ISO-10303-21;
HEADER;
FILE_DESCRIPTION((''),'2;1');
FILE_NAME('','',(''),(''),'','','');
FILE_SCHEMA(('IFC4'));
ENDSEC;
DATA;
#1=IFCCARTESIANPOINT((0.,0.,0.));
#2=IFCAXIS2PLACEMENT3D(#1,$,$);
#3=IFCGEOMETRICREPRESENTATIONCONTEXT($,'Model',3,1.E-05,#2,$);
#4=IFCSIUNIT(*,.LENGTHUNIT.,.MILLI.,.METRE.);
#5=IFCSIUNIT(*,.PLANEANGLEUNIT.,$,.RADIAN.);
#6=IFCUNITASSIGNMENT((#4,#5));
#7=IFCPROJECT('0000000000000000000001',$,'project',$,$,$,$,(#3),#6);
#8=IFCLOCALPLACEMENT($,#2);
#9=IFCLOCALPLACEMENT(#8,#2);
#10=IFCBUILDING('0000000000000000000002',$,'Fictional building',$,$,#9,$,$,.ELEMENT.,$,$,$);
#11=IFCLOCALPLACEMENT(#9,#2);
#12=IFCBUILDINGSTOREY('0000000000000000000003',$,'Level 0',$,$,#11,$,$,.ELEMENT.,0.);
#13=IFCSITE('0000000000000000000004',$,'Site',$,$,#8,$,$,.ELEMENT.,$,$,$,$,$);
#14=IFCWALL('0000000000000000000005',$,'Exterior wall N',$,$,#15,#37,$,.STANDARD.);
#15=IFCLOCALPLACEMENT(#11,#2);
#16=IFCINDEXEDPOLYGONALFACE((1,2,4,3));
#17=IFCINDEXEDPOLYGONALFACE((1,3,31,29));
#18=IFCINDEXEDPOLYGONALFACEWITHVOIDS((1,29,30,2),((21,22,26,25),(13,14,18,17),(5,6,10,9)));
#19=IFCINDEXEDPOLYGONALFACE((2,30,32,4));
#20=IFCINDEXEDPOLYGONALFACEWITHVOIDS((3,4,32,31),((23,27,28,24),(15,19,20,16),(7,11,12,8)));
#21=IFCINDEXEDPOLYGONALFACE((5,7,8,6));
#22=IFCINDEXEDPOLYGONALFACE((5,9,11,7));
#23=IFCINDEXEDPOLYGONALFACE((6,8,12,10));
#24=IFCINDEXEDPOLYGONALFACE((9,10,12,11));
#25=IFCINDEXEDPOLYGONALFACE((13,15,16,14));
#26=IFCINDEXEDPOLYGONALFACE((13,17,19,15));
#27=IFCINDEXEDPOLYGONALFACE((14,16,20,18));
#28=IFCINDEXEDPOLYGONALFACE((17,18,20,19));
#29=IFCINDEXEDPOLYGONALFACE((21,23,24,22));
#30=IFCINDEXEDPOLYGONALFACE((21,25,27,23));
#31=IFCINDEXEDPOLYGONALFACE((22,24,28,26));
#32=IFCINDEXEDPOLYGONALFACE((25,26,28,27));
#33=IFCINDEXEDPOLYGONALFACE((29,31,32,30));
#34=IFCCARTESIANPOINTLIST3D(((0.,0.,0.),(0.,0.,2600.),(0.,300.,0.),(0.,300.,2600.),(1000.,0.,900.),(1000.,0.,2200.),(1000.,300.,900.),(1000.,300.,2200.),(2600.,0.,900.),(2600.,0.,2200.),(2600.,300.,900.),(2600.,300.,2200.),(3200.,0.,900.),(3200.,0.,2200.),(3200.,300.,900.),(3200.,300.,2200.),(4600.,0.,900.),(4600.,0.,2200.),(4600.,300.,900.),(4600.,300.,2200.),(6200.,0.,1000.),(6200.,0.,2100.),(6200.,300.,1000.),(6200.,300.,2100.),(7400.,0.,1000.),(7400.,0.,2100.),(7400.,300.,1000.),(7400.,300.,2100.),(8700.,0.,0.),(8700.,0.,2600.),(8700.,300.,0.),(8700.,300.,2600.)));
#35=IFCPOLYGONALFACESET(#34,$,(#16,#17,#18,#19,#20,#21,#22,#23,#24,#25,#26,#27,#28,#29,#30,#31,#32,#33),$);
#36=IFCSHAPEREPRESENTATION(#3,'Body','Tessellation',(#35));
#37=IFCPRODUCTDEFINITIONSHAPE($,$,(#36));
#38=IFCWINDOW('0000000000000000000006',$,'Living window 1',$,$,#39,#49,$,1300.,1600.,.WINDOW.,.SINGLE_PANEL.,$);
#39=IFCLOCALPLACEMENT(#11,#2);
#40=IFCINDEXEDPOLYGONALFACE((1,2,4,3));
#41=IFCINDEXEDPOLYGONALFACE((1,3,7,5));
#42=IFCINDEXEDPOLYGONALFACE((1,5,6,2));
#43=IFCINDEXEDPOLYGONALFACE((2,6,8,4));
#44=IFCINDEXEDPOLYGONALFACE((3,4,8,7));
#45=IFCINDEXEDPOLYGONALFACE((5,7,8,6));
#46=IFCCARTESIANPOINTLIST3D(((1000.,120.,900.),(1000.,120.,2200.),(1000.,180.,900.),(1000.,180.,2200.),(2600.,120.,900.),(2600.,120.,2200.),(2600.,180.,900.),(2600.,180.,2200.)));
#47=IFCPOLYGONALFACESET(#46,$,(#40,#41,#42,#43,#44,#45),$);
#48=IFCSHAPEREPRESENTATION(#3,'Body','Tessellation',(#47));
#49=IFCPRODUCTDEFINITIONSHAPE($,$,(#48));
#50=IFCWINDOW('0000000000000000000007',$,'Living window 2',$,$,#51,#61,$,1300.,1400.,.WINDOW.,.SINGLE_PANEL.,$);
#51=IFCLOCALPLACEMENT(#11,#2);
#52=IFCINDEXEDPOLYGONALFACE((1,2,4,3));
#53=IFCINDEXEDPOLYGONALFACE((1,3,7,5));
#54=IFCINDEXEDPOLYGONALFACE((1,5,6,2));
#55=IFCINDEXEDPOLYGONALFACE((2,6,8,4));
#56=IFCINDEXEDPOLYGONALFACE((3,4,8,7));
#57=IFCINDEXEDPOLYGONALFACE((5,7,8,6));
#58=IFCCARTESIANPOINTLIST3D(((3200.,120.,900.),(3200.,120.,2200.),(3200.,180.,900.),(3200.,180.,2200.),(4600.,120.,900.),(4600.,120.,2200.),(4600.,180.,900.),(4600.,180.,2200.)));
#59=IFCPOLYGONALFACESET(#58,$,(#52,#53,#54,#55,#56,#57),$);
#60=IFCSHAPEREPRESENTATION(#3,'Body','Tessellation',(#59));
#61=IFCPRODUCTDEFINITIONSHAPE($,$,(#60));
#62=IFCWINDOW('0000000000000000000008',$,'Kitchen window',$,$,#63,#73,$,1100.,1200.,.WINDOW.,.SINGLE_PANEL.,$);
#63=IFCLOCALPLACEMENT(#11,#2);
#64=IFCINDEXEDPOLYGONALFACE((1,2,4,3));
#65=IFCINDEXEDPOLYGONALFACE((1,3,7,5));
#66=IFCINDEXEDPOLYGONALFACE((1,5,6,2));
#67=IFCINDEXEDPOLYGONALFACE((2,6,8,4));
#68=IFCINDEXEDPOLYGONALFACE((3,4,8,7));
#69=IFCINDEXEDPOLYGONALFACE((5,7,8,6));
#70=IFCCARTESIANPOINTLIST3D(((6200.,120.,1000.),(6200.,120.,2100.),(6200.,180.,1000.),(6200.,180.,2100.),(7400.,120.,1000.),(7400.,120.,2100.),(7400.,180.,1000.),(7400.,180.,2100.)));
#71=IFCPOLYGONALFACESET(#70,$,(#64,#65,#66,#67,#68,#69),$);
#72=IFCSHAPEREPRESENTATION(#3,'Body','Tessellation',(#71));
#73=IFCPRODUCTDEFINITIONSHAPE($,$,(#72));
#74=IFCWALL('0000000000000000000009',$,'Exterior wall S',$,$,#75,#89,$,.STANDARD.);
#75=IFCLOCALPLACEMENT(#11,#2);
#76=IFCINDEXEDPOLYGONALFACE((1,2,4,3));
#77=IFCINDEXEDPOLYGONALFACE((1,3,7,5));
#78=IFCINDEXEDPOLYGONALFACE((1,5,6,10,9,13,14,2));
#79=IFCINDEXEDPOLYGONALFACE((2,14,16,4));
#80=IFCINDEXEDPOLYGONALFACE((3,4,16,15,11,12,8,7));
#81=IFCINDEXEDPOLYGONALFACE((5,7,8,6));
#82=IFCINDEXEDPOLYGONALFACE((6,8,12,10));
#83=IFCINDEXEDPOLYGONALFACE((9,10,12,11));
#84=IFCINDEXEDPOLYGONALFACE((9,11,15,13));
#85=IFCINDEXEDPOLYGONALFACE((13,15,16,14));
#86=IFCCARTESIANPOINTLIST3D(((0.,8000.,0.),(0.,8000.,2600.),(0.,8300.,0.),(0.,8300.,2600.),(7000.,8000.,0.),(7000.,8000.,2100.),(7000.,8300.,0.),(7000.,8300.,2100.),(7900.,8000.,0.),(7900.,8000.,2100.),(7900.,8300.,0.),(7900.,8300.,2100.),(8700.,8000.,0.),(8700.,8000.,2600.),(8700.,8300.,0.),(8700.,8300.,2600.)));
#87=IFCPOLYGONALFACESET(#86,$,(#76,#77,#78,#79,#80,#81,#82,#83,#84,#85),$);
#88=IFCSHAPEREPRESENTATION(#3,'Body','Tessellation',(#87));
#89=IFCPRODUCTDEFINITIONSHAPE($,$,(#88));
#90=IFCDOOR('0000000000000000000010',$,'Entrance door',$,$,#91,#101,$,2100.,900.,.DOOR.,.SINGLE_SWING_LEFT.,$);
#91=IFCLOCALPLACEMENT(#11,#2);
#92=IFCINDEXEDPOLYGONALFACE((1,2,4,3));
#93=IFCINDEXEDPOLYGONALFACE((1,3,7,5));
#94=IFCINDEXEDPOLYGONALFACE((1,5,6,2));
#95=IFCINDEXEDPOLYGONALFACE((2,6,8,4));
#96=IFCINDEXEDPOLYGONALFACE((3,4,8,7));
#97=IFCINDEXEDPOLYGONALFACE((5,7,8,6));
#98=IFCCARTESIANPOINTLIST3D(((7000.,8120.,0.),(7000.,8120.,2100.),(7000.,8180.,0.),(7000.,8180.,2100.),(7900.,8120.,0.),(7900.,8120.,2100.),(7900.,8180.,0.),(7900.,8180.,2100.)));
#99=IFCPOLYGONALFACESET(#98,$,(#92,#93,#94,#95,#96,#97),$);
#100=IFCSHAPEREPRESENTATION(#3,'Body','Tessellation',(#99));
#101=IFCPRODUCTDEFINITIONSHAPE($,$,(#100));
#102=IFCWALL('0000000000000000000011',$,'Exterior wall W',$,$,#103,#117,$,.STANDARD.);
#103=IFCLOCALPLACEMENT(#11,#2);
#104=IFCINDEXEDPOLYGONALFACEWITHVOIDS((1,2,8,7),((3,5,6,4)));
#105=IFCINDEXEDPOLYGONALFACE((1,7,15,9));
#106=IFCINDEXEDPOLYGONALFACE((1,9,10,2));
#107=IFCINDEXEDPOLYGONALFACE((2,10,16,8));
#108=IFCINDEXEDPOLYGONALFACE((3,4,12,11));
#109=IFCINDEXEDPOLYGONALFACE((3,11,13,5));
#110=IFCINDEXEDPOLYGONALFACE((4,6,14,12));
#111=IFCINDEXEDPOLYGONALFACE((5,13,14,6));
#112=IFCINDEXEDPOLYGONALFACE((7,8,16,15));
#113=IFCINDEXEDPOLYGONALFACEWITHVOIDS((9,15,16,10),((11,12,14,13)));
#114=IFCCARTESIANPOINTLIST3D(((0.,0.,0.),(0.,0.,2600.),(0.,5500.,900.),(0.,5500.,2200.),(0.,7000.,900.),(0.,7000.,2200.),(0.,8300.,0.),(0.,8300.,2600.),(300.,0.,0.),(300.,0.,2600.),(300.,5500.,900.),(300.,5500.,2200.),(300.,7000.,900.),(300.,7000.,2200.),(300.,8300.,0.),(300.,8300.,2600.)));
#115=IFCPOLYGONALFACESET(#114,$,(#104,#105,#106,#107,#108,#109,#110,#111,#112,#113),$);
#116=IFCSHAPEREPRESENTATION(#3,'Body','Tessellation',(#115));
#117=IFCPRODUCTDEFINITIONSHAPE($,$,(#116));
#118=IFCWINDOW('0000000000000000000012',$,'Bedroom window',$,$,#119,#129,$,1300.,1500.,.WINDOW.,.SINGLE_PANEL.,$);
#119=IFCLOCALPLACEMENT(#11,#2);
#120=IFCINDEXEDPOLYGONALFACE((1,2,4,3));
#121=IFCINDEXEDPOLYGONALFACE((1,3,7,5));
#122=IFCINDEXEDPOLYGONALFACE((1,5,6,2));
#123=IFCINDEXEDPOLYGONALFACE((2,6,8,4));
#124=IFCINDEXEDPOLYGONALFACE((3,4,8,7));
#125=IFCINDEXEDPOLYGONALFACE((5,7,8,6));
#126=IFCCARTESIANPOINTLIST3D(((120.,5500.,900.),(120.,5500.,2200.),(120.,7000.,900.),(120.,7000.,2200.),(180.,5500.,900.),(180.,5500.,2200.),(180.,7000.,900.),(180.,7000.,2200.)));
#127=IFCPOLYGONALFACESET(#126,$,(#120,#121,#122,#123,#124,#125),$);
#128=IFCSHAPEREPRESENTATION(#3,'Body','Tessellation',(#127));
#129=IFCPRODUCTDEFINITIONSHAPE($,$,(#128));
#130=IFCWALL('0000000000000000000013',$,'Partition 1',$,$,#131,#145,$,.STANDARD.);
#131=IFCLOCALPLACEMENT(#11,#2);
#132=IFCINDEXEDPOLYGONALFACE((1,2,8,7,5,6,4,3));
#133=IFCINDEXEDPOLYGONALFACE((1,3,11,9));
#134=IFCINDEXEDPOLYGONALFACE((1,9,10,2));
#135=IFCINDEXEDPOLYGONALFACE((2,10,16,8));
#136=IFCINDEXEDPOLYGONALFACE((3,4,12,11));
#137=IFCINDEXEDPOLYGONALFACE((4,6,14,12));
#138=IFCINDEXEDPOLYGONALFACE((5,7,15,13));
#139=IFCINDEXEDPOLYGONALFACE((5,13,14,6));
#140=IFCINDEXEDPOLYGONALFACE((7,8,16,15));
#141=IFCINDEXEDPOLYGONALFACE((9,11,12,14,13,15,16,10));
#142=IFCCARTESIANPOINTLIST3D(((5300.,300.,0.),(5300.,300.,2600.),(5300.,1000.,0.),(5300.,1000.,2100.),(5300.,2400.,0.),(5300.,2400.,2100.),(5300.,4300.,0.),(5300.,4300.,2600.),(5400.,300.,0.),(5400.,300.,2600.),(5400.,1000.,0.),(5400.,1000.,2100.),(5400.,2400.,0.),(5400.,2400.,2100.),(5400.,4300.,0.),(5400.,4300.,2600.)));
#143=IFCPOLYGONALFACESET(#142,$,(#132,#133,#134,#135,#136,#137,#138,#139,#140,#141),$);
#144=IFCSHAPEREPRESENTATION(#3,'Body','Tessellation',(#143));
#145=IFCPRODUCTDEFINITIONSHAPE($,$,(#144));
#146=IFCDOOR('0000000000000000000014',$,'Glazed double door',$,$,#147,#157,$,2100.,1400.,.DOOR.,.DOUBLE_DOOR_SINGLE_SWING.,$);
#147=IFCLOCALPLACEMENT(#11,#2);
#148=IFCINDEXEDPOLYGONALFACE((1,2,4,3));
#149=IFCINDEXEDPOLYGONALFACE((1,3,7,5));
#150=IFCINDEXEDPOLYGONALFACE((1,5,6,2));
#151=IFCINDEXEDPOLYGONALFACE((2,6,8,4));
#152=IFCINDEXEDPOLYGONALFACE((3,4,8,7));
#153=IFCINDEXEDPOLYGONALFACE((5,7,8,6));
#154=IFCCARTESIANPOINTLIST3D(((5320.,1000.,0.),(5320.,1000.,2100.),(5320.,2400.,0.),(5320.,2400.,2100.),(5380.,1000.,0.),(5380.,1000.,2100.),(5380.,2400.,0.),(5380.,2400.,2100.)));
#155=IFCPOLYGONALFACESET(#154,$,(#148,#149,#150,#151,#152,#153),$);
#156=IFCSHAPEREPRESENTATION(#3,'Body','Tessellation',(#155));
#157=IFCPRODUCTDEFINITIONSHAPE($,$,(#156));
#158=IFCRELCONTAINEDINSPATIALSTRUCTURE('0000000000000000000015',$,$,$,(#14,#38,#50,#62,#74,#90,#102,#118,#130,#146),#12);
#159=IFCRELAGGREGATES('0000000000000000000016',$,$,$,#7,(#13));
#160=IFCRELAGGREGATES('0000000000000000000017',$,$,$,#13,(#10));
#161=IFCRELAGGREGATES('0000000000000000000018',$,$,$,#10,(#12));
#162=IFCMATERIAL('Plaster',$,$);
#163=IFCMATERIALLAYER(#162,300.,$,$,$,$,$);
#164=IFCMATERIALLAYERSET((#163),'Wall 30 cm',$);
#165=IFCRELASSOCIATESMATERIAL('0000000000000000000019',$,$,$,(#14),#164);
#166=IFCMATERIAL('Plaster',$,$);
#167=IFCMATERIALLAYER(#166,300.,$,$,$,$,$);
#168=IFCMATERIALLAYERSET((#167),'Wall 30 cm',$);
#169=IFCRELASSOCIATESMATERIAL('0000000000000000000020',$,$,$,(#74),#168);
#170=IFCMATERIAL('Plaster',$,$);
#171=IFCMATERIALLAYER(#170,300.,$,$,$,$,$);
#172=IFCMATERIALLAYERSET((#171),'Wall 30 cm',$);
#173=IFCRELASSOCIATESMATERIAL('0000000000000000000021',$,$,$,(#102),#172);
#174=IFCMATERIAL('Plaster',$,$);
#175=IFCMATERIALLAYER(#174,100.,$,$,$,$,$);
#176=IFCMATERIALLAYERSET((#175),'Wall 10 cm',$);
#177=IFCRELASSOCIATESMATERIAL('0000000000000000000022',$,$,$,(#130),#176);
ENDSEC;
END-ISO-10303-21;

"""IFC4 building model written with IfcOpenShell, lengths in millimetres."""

from ifc_helpers import new_model, si_unit, frame, frame_2d, origin, place, context, project, spatial, rectangle, extrude, material, layer, layer_set, layer_usage, element, fill, save


model = new_model("IFC4")

# Units and contexts
model_context = context("Model", 3, precision=1e-05, world=origin())
ifc_project = project(units=[si_unit("LENGTHUNIT", "METRE", prefix="MILLI"), si_unit("PLANEANGLEUNIT", "RADIAN")], contexts=[model_context])

# Site, building, storey
site_placement = place(None, origin())
site = spatial("IfcSite", under=ifc_project, at=site_placement, Name="Site", CompositionType="ELEMENT")
building_placement = place(site_placement, origin())
building = spatial("IfcBuilding", under=site, at=building_placement, Name="Fictional building", CompositionType="ELEMENT")
storey_placement = place(building_placement, origin())
storey = spatial("IfcBuildingStorey", under=building, at=storey_placement, Name="Level 0", CompositionType="ELEMENT", Elevation=0.0)

# Wall, openings, windows
ifc_material_1 = material(Name="Plaster")
ifc_layer_1 = layer(ifc_material_1, 300.0)
ifc_layer_set_1 = layer_set([ifc_layer_1], Name="Wall 30 cm")
ifc_layer_usage_1 = layer_usage(ifc_layer_set_1, "AXIS2", "POSITIVE", -150.0)
wall_1_placement = place(storey_placement, frame((0.0, 150.0, 0.0)))
wall_1 = element("IfcWall", 1, at=wall_1_placement, inside=storey, material=ifc_layer_usage_1, Name="Exterior wall N", PredefinedType="STANDARD", context=model_context, shape_type="SweptSolid", body=[
    extrude(rectangle(XDim=8700.0, YDim=300.0, at=frame_2d((4350.0, 0.0))), origin(), (0.0, 0.0, 1.0), 2600.0),
])
opening_1_placement = place(storey_placement, frame((1000.0, 150.0, 900.0)))
opening_1 = element("IfcOpeningElement", 2, at=opening_1_placement, cuts=wall_1, PredefinedType="OPENING", context=model_context, shape_type="SweptSolid", body=[
    extrude(rectangle(XDim=1600.0, YDim=300.0, at=frame_2d((800.0, 0.0))), origin(), (0.0, 0.0, 1.0), 1300.0),
])
opening_2_placement = place(storey_placement, frame((3200.0, 150.0, 900.0)))
opening_2 = element("IfcOpeningElement", 3, at=opening_2_placement, cuts=wall_1, PredefinedType="OPENING", context=model_context, shape_type="SweptSolid", body=[
    extrude(rectangle(XDim=1400.0, YDim=300.0, at=frame_2d((700.0, 0.0))), origin(), (0.0, 0.0, 1.0), 1300.0),
])
opening_3_placement = place(storey_placement, frame((6200.0, 150.0, 1000.0)))
opening_3 = element("IfcOpeningElement", 4, at=opening_3_placement, cuts=wall_1, PredefinedType="OPENING", context=model_context, shape_type="SweptSolid", body=[
    extrude(rectangle(XDim=1200.0, YDim=300.0, at=frame_2d((600.0, 0.0))), origin(), (0.0, 0.0, 1.0), 1100.0),
])
window_1_placement = place(opening_1_placement, origin())
window_1 = element("IfcWindow", 5, at=window_1_placement, inside=storey, Name="Living window 1", OverallHeight=1300.0, OverallWidth=1600.0, PartitioningType="SINGLE_PANEL", PredefinedType="WINDOW", context=model_context, shape_type="SweptSolid", body=[
    extrude(rectangle(XDim=1600.0, YDim=60.0, at=frame_2d((800.0, 0.0))), origin(), (0.0, 0.0, 1.0), 1300.0),
])
fill(opening_1, window_1)
window_2_placement = place(opening_2_placement, origin())
window_2 = element("IfcWindow", 6, at=window_2_placement, inside=storey, Name="Living window 2", OverallHeight=1300.0, OverallWidth=1400.0, PartitioningType="SINGLE_PANEL", PredefinedType="WINDOW", context=model_context, shape_type="SweptSolid", body=[
    extrude(rectangle(XDim=1400.0, YDim=60.0, at=frame_2d((700.0, 0.0))), origin(), (0.0, 0.0, 1.0), 1300.0),
])
fill(opening_2, window_2)
window_3_placement = place(opening_3_placement, origin())
window_3 = element("IfcWindow", 7, at=window_3_placement, inside=storey, Name="Kitchen window", OverallHeight=1100.0, OverallWidth=1200.0, PartitioningType="SINGLE_PANEL", PredefinedType="WINDOW", context=model_context, shape_type="SweptSolid", body=[
    extrude(rectangle(XDim=1200.0, YDim=60.0, at=frame_2d((600.0, 0.0))), origin(), (0.0, 0.0, 1.0), 1100.0),
])
fill(opening_3, window_3)

# Wall, opening, door
ifc_material_2 = material(Name="Plaster")
ifc_layer_2 = layer(ifc_material_2, 300.0)
ifc_layer_set_2 = layer_set([ifc_layer_2], Name="Wall 30 cm")
ifc_layer_usage_2 = layer_usage(ifc_layer_set_2, "AXIS2", "POSITIVE", -150.0)
wall_2_placement = place(storey_placement, frame((0.0, 8150.0, 0.0)))
wall_2 = element("IfcWall", 8, at=wall_2_placement, inside=storey, material=ifc_layer_usage_2, Name="Exterior wall S", PredefinedType="STANDARD", context=model_context, shape_type="SweptSolid", body=[
    extrude(rectangle(XDim=8700.0, YDim=300.0, at=frame_2d((4350.0, 0.0))), origin(), (0.0, 0.0, 1.0), 2600.0),
])
opening_4_placement = place(storey_placement, frame((7900.0, 8150.0, 0.0), z_axis=(0.0, 0.0, 1.0), x_axis=(-1.0, 0.0, 0.0)))
opening_4 = element("IfcOpeningElement", 9, at=opening_4_placement, cuts=wall_2, PredefinedType="OPENING", context=model_context, shape_type="SweptSolid", body=[
    extrude(rectangle(XDim=900.0, YDim=300.0, at=frame_2d((450.0, 0.0))), origin(), (0.0, 0.0, 1.0), 2100.0),
])
door_1_placement = place(opening_4_placement, origin())
door_1 = element("IfcDoor", 10, at=door_1_placement, inside=storey, Name="Entrance door", OperationType="SINGLE_SWING_LEFT", OverallHeight=2100.0, OverallWidth=900.0, PredefinedType="DOOR", context=model_context, shape_type="SweptSolid", body=[
    extrude(rectangle(XDim=900.0, YDim=60.0, at=frame_2d((450.0, 0.0))), origin(), (0.0, 0.0, 1.0), 2100.0),
])
fill(opening_4, door_1)

# Wall, opening, window
ifc_material_3 = material(Name="Plaster")
ifc_layer_3 = layer(ifc_material_3, 300.0)
ifc_layer_set_3 = layer_set([ifc_layer_3], Name="Wall 30 cm")
ifc_layer_usage_3 = layer_usage(ifc_layer_set_3, "AXIS2", "POSITIVE", -150.0)
wall_3_placement = place(storey_placement, frame((150.0, 0.0, 0.0), z_axis=(0.0, 0.0, 1.0), x_axis=(0.0, 1.0, 0.0)))
wall_3 = element("IfcWall", 11, at=wall_3_placement, inside=storey, material=ifc_layer_usage_3, Name="Exterior wall W", PredefinedType="STANDARD", context=model_context, shape_type="SweptSolid", body=[
    extrude(rectangle(XDim=8300.0, YDim=300.0, at=frame_2d((4150.0, 0.0))), origin(), (0.0, 0.0, 1.0), 2600.0),
])
opening_5_placement = place(storey_placement, frame((150.0, 5500.0, 900.0), z_axis=(0.0, 0.0, 1.0), x_axis=(0.0, 1.0, 0.0)))
opening_5 = element("IfcOpeningElement", 12, at=opening_5_placement, cuts=wall_3, PredefinedType="OPENING", context=model_context, shape_type="SweptSolid", body=[
    extrude(rectangle(XDim=1500.0, YDim=300.0, at=frame_2d((750.0, 0.0))), origin(), (0.0, 0.0, 1.0), 1300.0),
])
window_4_placement = place(opening_5_placement, origin())
window_4 = element("IfcWindow", 13, at=window_4_placement, inside=storey, Name="Bedroom window", OverallHeight=1300.0, OverallWidth=1500.0, PartitioningType="SINGLE_PANEL", PredefinedType="WINDOW", context=model_context, shape_type="SweptSolid", body=[
    extrude(rectangle(XDim=1500.0, YDim=60.0, at=frame_2d((750.0, 0.0))), origin(), (0.0, 0.0, 1.0), 1300.0),
])
fill(opening_5, window_4)

# Wall, opening, door
ifc_material_4 = material(Name="Plaster")
ifc_layer_4 = layer(ifc_material_4, 100.0)
ifc_layer_set_4 = layer_set([ifc_layer_4], Name="Wall 10 cm")
ifc_layer_usage_4 = layer_usage(ifc_layer_set_4, "AXIS2", "POSITIVE", -50.0)
wall_4_placement = place(storey_placement, frame((5350.0, 300.0, 0.0), z_axis=(0.0, 0.0, 1.0), x_axis=(0.0, 1.0, 0.0)))
wall_4 = element("IfcWall", 14, at=wall_4_placement, inside=storey, material=ifc_layer_usage_4, Name="Partition 1", PredefinedType="STANDARD", context=model_context, shape_type="SweptSolid", body=[
    extrude(rectangle(XDim=4000.0, YDim=100.0, at=frame_2d((2000.0, 0.0))), origin(), (0.0, 0.0, 1.0), 2600.0),
])
opening_6_placement = place(storey_placement, frame((5350.0, 1000.0, 0.0), z_axis=(0.0, 0.0, 1.0), x_axis=(0.0, 1.0, 0.0)))
opening_6 = element("IfcOpeningElement", 15, at=opening_6_placement, cuts=wall_4, PredefinedType="OPENING", context=model_context, shape_type="SweptSolid", body=[
    extrude(rectangle(XDim=1400.0, YDim=200.0, at=frame_2d((700.0, 0.0))), origin(), (0.0, 0.0, 1.0), 2100.0),
])
door_2_placement = place(opening_6_placement, origin())
door_2 = element("IfcDoor", 16, at=door_2_placement, inside=storey, Name="Glazed double door", OperationType="DOUBLE_DOOR_SINGLE_SWING", OverallHeight=2100.0, OverallWidth=1400.0, PredefinedType="DOOR", context=model_context, shape_type="SweptSolid", body=[
    extrude(rectangle(XDim=1400.0, YDim=60.0, at=frame_2d((700.0, 0.0))), origin(), (0.0, 0.0, 1.0), 2100.0),
])
fill(opening_6, door_2)

save(model, "model.ifc")
